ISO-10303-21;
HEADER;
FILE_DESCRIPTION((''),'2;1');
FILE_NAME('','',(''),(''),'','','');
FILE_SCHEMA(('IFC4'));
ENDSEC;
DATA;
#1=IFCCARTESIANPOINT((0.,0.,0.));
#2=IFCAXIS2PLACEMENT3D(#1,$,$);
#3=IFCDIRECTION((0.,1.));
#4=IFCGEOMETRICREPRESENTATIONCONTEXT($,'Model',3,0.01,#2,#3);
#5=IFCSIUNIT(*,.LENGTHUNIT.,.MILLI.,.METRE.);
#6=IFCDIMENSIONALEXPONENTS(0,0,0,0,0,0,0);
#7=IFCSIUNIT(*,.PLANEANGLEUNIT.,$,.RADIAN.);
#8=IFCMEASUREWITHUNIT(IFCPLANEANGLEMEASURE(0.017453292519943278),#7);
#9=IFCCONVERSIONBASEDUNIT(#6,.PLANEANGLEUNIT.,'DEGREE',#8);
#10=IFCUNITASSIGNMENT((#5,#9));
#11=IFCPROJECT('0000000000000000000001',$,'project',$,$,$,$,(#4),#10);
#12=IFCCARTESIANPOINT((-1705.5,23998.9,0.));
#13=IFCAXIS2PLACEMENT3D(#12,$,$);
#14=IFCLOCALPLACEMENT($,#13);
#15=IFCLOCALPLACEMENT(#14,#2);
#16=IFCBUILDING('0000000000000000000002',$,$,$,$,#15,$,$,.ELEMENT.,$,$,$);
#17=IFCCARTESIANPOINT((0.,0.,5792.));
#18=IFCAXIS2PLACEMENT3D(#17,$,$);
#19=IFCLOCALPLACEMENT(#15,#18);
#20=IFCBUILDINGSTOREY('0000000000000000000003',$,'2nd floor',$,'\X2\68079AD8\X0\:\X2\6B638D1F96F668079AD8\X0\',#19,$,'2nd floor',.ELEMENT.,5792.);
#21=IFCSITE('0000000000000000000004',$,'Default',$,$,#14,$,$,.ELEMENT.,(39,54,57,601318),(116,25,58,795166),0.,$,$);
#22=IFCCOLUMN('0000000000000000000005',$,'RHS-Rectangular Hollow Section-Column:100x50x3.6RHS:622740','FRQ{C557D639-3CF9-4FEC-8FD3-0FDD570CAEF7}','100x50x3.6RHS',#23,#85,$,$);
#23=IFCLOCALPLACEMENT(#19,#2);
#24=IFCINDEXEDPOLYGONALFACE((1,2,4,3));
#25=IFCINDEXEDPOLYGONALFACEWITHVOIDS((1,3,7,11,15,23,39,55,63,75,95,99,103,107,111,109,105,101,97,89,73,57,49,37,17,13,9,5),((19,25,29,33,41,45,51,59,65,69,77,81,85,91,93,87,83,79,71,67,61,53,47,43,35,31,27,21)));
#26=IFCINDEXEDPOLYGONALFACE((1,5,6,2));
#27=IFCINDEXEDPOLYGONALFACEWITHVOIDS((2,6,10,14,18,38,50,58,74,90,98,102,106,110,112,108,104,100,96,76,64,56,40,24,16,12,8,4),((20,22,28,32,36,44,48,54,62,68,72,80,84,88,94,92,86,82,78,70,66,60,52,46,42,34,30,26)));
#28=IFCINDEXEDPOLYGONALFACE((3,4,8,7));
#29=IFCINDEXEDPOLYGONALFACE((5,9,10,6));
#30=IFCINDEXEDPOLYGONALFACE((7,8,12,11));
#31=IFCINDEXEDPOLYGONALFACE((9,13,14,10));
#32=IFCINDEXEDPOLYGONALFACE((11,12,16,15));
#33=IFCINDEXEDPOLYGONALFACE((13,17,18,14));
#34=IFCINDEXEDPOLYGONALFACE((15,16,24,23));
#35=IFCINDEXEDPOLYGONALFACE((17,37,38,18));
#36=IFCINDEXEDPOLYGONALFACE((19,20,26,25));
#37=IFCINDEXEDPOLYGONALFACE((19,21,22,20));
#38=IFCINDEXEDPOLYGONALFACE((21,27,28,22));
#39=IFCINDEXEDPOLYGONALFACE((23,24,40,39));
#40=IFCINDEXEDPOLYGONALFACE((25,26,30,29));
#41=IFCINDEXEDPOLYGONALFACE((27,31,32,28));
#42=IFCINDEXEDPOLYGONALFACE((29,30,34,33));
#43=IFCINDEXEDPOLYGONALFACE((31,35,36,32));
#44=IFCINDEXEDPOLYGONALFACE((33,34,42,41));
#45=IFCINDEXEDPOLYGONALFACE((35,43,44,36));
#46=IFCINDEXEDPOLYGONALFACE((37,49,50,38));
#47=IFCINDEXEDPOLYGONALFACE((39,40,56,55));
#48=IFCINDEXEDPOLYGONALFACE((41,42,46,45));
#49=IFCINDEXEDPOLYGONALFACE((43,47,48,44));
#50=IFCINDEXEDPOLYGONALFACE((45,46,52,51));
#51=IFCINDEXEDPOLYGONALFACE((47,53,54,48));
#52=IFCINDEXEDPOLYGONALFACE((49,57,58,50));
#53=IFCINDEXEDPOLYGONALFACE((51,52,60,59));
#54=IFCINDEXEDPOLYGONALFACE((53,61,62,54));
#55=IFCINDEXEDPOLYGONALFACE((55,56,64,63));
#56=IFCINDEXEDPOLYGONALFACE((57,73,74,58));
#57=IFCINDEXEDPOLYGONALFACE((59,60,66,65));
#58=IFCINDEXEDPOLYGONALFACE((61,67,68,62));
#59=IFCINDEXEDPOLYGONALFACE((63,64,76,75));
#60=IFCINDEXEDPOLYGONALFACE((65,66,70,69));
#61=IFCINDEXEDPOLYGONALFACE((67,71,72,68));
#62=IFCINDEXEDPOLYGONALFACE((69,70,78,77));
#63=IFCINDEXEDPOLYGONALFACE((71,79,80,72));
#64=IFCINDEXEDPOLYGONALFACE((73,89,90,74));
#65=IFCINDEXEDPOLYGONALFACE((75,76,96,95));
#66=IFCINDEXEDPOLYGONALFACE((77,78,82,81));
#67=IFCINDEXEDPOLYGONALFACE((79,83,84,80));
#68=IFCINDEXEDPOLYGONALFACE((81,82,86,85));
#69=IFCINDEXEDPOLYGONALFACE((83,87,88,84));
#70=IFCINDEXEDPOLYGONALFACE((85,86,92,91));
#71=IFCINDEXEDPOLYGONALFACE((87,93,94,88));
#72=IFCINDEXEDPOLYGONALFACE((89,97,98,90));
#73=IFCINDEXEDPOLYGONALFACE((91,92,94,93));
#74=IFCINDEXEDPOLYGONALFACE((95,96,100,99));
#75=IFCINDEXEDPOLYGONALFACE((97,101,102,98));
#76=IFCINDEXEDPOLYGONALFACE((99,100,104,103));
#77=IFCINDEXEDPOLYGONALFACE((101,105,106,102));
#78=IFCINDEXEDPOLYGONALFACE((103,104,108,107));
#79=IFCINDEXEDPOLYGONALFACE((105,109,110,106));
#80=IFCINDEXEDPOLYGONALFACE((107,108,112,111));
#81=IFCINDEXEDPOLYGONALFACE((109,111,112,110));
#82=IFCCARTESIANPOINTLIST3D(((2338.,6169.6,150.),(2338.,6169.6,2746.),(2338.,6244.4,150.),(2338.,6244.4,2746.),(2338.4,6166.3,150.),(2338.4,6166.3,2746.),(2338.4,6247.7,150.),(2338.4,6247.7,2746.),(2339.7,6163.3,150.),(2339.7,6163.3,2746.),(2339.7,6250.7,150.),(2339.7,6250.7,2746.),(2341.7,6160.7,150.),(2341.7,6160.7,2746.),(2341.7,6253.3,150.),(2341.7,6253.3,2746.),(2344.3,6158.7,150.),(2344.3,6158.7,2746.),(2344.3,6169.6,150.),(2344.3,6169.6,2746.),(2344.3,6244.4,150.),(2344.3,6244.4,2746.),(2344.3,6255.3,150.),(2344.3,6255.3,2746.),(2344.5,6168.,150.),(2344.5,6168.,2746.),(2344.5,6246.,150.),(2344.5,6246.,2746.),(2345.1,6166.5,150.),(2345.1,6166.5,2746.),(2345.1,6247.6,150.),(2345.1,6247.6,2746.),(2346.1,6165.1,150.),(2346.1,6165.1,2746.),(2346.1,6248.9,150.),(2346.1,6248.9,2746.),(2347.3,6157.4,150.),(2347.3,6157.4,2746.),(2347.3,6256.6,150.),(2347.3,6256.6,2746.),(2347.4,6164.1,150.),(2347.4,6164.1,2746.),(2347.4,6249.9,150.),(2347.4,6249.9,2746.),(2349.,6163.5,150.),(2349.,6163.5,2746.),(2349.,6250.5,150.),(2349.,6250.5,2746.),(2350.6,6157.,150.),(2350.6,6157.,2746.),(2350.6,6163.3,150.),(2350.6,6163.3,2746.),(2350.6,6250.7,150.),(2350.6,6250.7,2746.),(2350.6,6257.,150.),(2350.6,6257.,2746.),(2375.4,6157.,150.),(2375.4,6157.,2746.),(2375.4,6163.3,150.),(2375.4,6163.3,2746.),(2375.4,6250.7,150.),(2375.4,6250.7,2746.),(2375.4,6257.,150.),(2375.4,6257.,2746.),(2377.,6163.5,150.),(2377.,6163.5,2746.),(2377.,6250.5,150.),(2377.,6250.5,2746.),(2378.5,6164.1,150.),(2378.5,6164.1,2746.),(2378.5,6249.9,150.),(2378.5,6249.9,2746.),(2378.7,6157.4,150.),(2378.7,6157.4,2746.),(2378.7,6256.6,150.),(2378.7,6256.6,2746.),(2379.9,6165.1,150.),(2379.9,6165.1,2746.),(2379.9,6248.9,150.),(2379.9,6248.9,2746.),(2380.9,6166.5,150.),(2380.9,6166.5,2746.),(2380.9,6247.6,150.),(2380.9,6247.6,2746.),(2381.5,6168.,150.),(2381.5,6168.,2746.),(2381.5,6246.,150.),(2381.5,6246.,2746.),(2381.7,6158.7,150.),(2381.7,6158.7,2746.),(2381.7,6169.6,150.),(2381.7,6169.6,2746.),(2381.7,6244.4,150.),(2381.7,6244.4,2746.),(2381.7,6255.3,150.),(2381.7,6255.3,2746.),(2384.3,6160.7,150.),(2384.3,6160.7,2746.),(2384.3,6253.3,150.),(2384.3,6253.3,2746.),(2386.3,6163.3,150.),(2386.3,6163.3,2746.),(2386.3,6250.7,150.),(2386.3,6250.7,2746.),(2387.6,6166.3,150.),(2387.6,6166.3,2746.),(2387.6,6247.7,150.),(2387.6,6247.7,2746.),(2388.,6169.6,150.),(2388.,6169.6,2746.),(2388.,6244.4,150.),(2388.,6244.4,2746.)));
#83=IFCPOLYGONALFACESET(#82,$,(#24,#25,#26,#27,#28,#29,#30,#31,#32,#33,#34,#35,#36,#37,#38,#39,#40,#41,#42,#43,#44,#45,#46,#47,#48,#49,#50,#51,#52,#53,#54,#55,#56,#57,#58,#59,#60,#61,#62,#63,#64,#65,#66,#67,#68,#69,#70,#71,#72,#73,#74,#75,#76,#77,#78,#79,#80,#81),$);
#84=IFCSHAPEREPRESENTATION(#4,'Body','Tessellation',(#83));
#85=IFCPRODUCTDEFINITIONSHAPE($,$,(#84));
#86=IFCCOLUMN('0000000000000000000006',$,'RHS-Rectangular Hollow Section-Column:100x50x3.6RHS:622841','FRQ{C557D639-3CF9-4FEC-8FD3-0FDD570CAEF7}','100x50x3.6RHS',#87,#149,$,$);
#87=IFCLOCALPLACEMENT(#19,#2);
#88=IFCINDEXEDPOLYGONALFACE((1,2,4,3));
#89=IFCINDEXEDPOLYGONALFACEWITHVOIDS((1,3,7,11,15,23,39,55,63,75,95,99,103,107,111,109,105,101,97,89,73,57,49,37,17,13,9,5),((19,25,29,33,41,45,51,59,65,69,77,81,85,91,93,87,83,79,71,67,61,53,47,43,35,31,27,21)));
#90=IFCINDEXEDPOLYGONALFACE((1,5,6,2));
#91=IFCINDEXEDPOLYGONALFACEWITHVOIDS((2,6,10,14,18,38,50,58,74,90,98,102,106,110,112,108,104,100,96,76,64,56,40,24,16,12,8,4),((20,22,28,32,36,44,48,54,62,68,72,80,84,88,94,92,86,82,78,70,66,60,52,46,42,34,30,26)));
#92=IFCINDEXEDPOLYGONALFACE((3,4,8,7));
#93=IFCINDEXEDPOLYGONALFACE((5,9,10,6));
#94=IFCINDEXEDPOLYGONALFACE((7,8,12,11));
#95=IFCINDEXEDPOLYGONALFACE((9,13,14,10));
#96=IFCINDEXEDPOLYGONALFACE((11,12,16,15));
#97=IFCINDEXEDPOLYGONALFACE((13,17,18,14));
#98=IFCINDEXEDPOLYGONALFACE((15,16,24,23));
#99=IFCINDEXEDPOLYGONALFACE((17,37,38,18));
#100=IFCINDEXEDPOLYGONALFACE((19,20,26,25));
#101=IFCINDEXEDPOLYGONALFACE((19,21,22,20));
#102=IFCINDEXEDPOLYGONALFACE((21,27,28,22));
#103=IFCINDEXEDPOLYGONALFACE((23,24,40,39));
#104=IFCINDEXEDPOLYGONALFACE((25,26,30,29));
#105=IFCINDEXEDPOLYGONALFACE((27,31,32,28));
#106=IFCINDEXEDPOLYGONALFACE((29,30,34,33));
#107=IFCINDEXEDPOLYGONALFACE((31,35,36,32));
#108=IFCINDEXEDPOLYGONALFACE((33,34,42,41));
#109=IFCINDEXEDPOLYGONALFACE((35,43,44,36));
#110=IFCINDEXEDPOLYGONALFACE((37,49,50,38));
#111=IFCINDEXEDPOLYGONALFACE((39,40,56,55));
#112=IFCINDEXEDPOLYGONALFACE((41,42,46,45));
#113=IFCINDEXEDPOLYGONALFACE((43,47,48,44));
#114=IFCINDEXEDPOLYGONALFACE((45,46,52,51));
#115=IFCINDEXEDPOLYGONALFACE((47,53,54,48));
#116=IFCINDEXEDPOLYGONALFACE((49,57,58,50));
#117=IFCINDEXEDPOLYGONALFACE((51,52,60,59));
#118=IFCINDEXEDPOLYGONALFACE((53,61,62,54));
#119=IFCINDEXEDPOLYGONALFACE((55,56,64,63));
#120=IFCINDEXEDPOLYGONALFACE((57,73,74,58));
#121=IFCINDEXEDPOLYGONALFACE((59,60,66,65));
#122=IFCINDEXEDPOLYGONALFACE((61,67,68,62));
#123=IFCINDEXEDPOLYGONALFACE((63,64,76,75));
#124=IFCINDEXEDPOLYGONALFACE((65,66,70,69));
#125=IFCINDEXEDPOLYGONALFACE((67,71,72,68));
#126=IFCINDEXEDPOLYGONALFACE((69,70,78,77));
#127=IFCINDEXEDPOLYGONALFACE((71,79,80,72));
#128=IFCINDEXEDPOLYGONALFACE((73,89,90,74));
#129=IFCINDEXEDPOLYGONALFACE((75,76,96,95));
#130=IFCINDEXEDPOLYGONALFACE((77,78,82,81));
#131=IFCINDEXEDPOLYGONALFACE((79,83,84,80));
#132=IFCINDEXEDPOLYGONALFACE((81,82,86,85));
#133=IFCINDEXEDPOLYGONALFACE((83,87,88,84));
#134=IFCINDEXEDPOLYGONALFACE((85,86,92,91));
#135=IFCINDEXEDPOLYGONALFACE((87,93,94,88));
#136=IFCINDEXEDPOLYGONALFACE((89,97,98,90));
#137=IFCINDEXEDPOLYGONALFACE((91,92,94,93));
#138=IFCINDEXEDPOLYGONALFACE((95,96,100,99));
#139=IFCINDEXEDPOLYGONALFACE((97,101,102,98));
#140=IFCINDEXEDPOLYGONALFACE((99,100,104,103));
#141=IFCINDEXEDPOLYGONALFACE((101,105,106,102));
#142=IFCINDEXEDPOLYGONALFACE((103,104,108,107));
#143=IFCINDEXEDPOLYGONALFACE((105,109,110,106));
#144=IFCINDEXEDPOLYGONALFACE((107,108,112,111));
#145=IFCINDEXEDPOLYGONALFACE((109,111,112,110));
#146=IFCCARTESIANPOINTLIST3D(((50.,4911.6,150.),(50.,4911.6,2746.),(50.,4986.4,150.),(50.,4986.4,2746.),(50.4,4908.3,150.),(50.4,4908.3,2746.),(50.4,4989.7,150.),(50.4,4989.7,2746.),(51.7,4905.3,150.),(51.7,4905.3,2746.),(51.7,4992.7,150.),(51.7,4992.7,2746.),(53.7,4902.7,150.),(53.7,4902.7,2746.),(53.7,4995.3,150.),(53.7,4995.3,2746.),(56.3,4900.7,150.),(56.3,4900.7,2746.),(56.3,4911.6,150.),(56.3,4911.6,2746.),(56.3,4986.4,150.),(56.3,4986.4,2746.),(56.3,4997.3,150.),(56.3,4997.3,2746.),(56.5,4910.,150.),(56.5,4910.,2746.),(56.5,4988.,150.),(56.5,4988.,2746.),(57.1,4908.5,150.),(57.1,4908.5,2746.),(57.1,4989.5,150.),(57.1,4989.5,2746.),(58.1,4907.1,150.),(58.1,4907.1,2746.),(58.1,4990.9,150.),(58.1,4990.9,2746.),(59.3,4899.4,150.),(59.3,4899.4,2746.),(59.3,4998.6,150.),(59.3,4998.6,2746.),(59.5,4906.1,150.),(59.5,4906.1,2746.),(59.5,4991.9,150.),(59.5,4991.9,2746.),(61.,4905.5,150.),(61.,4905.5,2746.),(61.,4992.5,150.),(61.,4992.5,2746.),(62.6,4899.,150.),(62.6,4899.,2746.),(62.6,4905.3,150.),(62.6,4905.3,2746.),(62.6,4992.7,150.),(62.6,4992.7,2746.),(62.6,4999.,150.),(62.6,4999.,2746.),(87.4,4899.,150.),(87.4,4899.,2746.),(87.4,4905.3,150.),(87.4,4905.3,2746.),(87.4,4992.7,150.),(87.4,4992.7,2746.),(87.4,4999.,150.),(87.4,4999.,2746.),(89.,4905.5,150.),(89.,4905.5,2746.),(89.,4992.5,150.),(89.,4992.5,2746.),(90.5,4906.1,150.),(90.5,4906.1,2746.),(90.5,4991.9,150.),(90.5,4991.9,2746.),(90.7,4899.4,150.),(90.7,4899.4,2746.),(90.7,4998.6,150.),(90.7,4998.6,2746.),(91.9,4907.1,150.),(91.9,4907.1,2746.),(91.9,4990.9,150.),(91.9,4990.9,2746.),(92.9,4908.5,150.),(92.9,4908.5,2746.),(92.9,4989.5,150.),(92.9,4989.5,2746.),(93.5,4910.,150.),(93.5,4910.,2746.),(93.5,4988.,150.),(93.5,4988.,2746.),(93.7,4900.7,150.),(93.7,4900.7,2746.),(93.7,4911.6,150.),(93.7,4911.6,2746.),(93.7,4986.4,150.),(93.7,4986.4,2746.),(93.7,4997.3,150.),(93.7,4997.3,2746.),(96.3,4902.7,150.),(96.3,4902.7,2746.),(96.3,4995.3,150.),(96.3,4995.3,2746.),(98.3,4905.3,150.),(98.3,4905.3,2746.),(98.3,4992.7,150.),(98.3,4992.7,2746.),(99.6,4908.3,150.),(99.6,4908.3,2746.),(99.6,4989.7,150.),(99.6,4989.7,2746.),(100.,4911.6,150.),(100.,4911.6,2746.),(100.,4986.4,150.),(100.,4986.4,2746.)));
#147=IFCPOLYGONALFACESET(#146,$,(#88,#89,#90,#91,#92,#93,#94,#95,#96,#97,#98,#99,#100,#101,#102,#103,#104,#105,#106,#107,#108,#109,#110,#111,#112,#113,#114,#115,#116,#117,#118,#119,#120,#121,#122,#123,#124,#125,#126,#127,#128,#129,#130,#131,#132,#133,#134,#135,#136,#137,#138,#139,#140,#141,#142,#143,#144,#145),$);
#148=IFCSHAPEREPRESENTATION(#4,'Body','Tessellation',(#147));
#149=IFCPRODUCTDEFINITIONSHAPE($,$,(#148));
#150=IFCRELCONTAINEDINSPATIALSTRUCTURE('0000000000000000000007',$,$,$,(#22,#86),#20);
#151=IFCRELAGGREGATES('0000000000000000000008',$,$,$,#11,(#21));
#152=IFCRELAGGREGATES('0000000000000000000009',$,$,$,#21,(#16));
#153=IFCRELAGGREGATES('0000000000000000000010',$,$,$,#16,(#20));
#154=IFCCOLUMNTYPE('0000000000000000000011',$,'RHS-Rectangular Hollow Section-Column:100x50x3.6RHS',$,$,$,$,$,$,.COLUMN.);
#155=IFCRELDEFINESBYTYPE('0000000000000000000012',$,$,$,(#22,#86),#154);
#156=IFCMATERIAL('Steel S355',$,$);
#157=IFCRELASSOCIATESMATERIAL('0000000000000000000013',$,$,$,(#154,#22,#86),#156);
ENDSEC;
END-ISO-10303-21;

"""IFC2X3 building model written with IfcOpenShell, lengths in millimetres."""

from ifc_helpers import new_model, entity, si_unit, converted_unit, direction, frame, origin, origin_2d, place, context, project, spatial, hollow_rectangle, extrude, clip, halfspace, material, type_object, element, save


model = new_model("IFC2X3")

# Units and contexts
model_context = context("Model", 3, precision=0.01, world=origin(), true_north=direction((0.0, 1.0)))
ifc_project = project(units=[si_unit("LENGTHUNIT", "METRE", prefix="MILLI"), converted_unit("PLANEANGLEUNIT", "DEGREE", entity("IfcPlaneAngleMeasure", 0.017453292519943278), si_unit("PLANEANGLEUNIT", "RADIAN"), dimensions=[0, 0, 0, 0, 0, 0, 0])], contexts=[model_context])

# Site, building, storey
site_placement = place(None, frame((-1705.5, 23998.9, 0.0)))
site = spatial("IfcSite", under=ifc_project, at=site_placement, Name="Default", CompositionType="ELEMENT", RefLatitude=(39, 54, 57, 601318), RefLongitude=(116, 25, 58, 795166), RefElevation=0.0)
building_placement = place(site_placement, origin())
building = spatial("IfcBuilding", under=site, at=building_placement, CompositionType="ELEMENT")
storey_placement = place(building_placement, frame((0.0, 0.0, 5792.0)))
storey = spatial("IfcBuildingStorey", under=building, at=storey_placement, Name="2nd floor", ObjectType="标高:正负零标高", LongName="2nd floor", CompositionType="ELEMENT", Elevation=5792.0)

# Shared definitions
ifc_material_1 = material(Name="Steel S355")

# Columns
column_type_1 = type_object("IfcColumnType", Name="RHS-Rectangular Hollow Section-Column:100x50x3.6RHS", PredefinedType="COLUMN", material=ifc_material_1)
column_1_placement = place(storey_placement, frame((2363.0, 6207.0, 2746.0), z_axis=(0.0, 0.0, 1.0), x_axis=(-1.0, 0.0, 0.0)))
element("IfcColumn", 1, at=column_1_placement, inside=storey, type_object=column_type_1, material=ifc_material_1, Name="RHS-Rectangular Hollow Section-Column:100x50x3.6RHS:622740", Description="FRQ{C557D639-3CF9-4FEC-8FD3-0FDD570CAEF7}", ObjectType="100x50x3.6RHS", context=model_context, shape_type="Clipping", body=[
    clip(extrude(hollow_rectangle(XDim=50.0, YDim=100.0, WallThickness=6.3, InnerFilletRadius=6.3, OuterFilletRadius=12.6, at=origin_2d()), origin(), (0.0, 0.0, -1.0), 2651.9), halfspace(frame((2363.0, 6207.0, -2596.0), z_axis=(0.0, 0.0, 1.0), x_axis=(-1.0, 0.0, 0.0)), True)),
])
column_2_placement = place(storey_placement, frame((75.0, 4949.0, 2746.0), z_axis=(0.0, 0.0, 1.0), x_axis=(-1.0, 0.0, 0.0)))
element("IfcColumn", 2, at=column_2_placement, inside=storey, type_object=column_type_1, material=ifc_material_1, Name="RHS-Rectangular Hollow Section-Column:100x50x3.6RHS:622841", Description="FRQ{C557D639-3CF9-4FEC-8FD3-0FDD570CAEF7}", ObjectType="100x50x3.6RHS", context=model_context, shape_type="Clipping", body=[
    clip(extrude(hollow_rectangle(XDim=50.0, YDim=100.0, WallThickness=6.3, InnerFilletRadius=6.3, OuterFilletRadius=12.6, at=origin_2d()), origin(), (0.0, 0.0, -1.0), 2651.9), halfspace(frame((75.0, 4949.0, -2596.0), z_axis=(0.0, 0.0, 1.0), x_axis=(-1.0, 0.0, 0.0)), True)),
])

save(model, "model.ifc")
